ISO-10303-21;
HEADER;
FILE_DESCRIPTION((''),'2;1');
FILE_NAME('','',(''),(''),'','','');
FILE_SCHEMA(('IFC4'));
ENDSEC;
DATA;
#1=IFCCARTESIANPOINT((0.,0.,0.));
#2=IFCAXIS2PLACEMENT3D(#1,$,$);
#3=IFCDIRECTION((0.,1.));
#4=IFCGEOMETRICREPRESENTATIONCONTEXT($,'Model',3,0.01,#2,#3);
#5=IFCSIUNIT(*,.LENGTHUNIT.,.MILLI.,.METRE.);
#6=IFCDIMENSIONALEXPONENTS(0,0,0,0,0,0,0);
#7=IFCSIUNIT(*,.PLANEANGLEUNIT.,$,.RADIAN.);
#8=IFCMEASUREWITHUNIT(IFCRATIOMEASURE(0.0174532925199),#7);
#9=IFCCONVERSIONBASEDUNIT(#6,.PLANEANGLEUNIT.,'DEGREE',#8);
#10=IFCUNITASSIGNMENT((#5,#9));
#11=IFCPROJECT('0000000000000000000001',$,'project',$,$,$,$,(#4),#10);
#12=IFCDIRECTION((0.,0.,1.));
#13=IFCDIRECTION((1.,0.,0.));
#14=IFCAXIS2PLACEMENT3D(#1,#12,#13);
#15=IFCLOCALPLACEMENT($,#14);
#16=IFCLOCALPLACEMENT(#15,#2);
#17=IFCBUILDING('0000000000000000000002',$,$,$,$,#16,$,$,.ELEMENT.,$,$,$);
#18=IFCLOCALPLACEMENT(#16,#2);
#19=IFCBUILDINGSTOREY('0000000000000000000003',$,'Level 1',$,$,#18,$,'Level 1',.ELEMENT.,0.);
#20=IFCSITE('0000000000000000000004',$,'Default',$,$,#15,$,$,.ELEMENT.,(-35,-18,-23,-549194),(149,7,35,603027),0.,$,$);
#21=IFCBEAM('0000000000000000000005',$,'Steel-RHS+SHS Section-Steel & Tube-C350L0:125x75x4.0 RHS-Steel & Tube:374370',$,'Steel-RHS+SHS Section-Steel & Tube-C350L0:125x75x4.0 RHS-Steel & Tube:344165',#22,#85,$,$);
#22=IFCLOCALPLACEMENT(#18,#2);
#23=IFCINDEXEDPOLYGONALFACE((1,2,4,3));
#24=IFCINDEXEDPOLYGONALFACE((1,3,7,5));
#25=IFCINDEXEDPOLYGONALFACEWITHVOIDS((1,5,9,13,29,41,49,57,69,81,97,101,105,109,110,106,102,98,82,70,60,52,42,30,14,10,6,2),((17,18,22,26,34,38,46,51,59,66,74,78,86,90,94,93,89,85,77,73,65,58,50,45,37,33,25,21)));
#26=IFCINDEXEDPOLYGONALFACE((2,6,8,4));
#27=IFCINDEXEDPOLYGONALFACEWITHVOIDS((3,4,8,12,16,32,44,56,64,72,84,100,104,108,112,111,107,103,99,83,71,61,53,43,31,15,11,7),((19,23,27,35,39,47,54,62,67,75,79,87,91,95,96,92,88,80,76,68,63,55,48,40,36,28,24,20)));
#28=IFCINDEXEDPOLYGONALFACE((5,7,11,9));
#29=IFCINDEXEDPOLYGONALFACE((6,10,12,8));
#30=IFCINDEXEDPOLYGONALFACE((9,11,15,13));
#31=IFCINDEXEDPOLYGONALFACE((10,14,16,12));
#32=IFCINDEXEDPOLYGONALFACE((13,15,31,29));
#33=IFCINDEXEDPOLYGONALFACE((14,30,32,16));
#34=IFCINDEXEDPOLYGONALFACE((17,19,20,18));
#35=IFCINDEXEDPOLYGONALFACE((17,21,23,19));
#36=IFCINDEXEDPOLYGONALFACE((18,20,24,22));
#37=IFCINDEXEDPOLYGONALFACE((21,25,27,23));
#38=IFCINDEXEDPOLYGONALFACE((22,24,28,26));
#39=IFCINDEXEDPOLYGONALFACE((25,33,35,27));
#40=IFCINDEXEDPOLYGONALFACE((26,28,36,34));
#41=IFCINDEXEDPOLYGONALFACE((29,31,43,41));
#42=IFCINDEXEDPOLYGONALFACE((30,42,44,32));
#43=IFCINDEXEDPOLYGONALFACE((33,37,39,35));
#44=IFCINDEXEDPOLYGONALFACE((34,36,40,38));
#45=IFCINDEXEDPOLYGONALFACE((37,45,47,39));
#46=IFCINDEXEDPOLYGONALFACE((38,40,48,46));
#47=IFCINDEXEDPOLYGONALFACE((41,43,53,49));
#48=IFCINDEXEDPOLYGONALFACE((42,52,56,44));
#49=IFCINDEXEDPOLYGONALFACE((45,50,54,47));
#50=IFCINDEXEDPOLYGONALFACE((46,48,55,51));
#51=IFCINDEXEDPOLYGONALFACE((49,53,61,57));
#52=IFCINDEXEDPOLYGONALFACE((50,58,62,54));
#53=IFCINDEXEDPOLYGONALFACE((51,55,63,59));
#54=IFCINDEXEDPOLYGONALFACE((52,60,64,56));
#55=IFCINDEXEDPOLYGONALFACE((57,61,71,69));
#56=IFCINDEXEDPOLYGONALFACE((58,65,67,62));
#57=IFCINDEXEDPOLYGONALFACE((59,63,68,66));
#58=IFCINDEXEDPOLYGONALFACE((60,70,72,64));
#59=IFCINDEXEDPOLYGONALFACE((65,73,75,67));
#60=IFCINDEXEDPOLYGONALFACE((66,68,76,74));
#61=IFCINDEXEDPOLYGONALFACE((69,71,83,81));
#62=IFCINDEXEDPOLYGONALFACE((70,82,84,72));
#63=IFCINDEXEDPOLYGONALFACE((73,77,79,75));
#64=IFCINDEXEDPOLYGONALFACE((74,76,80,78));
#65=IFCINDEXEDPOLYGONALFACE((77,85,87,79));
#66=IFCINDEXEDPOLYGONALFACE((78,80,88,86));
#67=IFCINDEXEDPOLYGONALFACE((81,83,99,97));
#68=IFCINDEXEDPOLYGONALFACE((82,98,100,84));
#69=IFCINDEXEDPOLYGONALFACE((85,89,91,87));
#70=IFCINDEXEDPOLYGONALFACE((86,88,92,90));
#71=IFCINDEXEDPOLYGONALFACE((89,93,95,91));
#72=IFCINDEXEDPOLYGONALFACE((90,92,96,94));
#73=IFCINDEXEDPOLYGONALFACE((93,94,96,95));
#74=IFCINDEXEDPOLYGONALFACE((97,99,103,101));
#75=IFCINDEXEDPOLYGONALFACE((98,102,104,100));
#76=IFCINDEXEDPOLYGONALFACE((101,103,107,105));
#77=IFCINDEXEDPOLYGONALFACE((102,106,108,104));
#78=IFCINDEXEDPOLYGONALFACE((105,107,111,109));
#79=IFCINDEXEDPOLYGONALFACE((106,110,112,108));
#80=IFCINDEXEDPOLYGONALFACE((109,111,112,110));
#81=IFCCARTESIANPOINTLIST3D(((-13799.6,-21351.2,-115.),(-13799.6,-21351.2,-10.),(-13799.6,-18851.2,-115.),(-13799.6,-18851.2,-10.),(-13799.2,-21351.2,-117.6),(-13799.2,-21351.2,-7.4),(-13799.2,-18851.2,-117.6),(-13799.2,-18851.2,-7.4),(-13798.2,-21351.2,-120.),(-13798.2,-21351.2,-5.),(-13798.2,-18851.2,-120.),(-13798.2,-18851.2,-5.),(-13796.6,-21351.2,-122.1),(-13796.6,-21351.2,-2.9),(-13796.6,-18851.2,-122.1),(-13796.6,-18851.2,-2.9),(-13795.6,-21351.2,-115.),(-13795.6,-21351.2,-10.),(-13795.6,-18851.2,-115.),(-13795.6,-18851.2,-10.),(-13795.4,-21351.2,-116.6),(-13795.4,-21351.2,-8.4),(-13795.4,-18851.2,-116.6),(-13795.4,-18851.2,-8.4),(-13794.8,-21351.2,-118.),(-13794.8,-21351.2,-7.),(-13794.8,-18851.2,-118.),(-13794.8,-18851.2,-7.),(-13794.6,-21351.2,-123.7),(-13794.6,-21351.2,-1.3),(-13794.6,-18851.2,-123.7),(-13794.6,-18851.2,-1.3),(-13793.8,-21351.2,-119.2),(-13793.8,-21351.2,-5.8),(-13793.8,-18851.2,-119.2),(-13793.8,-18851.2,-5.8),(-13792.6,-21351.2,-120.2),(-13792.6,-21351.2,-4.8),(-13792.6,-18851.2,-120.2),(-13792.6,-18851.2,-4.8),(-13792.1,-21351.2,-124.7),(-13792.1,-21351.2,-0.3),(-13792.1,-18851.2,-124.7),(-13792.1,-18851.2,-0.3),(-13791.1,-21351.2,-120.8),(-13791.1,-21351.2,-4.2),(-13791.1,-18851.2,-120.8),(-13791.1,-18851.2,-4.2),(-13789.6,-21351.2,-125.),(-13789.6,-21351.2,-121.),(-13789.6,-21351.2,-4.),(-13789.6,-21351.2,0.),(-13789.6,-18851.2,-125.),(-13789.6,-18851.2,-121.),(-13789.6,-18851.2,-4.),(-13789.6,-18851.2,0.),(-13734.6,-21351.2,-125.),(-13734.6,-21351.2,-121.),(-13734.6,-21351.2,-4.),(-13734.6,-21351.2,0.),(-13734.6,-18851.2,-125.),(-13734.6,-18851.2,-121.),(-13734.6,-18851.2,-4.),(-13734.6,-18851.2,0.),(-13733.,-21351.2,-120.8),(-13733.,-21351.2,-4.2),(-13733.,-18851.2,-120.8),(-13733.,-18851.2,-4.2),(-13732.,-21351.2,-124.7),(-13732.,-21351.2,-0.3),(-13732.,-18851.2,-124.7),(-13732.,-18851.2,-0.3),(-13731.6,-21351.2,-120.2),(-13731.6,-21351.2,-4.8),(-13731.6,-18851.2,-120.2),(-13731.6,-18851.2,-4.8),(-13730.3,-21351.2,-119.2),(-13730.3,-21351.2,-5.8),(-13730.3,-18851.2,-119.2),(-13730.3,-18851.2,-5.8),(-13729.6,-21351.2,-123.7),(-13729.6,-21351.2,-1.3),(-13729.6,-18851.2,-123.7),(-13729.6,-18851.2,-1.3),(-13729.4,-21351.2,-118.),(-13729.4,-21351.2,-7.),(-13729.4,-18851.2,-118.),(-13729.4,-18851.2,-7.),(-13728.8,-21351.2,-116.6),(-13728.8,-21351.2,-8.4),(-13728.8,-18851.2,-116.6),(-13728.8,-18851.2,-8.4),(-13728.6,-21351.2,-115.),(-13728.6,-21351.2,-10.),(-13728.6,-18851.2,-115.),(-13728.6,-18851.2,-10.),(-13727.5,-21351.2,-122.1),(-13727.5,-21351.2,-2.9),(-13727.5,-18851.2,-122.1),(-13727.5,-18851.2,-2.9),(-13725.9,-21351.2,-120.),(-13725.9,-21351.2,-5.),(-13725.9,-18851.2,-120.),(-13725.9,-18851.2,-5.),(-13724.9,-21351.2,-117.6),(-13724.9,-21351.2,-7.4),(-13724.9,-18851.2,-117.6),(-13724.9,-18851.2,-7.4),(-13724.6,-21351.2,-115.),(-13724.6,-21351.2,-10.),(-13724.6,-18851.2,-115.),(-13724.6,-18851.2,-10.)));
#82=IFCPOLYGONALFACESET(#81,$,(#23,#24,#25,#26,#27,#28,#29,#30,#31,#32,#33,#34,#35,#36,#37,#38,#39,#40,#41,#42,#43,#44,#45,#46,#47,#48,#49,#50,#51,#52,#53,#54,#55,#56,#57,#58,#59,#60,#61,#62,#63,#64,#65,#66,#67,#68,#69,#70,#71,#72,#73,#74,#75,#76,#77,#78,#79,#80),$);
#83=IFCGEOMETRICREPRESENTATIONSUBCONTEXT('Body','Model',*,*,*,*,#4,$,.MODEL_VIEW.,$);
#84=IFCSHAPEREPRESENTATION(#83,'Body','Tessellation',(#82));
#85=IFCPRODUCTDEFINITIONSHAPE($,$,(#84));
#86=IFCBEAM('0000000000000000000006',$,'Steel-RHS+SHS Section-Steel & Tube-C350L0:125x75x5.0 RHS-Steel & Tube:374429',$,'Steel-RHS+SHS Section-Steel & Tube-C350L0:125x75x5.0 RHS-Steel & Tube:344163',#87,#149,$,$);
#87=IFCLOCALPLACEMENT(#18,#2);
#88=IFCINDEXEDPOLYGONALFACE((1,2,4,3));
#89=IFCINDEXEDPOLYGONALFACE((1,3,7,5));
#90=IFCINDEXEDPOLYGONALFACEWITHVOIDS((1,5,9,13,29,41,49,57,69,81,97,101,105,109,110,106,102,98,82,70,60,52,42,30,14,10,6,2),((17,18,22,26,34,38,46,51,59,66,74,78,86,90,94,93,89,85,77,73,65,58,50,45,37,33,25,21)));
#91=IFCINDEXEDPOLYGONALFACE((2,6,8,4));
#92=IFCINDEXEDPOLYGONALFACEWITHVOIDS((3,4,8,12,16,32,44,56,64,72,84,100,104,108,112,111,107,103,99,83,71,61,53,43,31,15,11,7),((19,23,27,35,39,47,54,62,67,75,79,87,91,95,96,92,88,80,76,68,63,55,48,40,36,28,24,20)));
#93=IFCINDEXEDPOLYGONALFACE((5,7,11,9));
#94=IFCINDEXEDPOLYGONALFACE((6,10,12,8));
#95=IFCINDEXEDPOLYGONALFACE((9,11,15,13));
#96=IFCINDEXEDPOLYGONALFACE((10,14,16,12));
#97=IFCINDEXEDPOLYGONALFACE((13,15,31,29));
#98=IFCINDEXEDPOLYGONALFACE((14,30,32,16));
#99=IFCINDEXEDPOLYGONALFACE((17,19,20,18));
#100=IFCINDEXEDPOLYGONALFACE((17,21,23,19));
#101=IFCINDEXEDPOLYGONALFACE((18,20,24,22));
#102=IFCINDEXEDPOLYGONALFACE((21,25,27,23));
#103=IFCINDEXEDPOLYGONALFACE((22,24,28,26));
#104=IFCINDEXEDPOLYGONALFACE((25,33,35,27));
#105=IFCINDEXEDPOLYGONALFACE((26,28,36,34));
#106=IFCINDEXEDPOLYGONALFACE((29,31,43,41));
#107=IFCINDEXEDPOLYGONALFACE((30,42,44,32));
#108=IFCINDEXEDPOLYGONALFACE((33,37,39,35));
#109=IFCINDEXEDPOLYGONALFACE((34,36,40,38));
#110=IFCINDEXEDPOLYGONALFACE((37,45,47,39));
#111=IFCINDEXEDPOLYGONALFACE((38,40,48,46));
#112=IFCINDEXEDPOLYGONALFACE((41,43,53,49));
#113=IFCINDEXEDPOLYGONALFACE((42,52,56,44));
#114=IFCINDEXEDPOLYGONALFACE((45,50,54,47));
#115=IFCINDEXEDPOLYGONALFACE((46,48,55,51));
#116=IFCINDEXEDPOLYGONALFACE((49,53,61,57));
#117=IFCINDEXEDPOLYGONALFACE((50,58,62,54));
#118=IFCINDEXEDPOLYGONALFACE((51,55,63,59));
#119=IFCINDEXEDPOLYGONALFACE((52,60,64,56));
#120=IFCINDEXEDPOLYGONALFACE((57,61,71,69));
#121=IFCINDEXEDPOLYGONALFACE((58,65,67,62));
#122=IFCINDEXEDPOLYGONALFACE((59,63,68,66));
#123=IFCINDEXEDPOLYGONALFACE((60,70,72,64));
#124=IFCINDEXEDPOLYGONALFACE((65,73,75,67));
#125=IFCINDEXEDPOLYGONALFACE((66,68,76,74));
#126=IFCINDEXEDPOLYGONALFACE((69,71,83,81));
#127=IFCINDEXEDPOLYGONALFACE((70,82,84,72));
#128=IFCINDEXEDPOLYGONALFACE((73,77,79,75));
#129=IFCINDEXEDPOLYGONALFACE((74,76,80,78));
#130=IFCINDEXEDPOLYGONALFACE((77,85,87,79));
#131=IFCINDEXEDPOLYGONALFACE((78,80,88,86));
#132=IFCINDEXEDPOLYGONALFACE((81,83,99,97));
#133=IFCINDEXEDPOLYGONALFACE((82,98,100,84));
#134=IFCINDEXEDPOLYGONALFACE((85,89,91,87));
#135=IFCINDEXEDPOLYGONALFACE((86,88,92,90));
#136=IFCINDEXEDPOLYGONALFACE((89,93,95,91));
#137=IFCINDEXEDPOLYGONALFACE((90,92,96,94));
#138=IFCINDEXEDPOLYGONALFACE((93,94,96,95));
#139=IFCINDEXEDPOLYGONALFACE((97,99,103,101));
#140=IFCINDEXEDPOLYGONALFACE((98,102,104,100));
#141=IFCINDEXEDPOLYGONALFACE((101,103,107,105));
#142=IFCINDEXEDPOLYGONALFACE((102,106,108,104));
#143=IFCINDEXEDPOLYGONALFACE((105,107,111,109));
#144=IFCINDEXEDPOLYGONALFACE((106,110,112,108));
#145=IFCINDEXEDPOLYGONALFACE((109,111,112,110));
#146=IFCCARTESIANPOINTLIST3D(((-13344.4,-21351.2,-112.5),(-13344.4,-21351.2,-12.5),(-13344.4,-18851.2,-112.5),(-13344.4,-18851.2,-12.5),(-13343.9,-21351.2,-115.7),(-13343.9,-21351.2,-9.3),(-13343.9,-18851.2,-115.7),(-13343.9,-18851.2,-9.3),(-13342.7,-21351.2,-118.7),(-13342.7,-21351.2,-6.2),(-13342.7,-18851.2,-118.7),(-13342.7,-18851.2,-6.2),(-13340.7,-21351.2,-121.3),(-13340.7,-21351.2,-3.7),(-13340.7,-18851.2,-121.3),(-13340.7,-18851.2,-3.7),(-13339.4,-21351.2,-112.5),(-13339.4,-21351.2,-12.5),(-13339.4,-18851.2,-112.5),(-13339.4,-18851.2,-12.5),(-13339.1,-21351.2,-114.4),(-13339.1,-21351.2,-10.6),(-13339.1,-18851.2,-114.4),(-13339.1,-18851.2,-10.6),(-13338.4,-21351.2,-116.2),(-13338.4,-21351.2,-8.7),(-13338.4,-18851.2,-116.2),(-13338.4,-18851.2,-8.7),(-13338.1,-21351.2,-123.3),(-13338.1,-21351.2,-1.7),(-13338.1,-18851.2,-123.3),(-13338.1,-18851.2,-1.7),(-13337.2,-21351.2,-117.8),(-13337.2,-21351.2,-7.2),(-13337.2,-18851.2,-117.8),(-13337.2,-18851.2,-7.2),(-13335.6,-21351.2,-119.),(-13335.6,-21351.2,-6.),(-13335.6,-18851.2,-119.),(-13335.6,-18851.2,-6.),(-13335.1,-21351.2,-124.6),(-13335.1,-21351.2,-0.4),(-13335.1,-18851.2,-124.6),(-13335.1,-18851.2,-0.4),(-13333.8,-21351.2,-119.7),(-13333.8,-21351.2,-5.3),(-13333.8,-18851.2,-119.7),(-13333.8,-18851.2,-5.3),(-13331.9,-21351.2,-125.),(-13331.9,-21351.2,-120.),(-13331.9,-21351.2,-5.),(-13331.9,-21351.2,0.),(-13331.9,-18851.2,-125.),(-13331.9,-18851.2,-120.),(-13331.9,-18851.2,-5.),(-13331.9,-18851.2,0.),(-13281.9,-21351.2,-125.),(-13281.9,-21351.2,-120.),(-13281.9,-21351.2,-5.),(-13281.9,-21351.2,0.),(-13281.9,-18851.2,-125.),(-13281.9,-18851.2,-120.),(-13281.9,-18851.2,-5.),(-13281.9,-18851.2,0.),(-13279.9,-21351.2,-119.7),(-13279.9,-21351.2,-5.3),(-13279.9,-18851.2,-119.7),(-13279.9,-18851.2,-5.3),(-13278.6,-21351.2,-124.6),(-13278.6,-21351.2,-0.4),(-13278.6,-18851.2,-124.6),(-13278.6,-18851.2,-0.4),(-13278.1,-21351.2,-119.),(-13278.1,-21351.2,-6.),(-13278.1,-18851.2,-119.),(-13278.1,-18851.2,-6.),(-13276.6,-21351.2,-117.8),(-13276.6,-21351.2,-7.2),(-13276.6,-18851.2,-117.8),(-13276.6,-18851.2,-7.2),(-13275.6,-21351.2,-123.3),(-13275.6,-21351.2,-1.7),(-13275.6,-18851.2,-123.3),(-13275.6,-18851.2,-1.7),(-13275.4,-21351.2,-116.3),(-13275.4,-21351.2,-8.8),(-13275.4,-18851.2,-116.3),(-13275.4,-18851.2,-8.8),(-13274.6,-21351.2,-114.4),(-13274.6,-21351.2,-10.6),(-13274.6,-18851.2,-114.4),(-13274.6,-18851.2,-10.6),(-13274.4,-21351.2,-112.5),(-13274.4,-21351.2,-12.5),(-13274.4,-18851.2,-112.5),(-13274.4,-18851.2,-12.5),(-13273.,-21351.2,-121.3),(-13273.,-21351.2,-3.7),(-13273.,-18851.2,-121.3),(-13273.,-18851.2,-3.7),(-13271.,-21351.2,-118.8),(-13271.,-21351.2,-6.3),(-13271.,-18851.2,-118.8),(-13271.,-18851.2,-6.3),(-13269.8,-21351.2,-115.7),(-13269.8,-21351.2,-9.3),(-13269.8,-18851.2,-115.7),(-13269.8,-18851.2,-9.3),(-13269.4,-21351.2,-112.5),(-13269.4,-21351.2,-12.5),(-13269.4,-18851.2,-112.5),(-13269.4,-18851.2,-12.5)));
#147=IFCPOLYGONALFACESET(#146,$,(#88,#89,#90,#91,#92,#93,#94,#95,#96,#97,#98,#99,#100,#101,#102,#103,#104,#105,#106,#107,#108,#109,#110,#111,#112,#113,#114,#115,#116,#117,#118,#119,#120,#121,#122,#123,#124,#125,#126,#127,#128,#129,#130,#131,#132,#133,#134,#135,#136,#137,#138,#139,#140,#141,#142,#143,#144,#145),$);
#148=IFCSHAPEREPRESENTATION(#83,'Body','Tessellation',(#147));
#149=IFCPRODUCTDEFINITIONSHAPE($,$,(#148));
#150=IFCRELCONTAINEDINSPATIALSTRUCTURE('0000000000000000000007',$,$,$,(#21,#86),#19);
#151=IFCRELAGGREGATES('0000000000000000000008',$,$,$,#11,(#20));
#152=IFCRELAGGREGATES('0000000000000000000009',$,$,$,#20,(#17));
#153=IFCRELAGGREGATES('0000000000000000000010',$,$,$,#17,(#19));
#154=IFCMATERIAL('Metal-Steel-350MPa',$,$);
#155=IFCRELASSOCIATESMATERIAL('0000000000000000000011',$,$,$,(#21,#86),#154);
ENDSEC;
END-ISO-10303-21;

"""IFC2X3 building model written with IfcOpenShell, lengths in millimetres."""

from ifc_helpers import new_model, entity, si_unit, converted_unit, direction, frame, frame_2d, origin, origin_with_axes, place, context, subcontext, project, spatial, polyline, circle_curve, parameter, trimmed, segment, composite_curve, outline, extrude, material, element, save


model = new_model("IFC2X3")

# Units and contexts
model_context = context("Model", 3, precision=0.01, world=origin(), true_north=direction((0.0, 1.0)))
body_context = subcontext(model_context, "Body", "Model", "MODEL_VIEW")
ifc_project = project(units=[si_unit("LENGTHUNIT", "METRE", prefix="MILLI"), converted_unit("PLANEANGLEUNIT", "DEGREE", entity("IfcRatioMeasure", 0.0174532925199), si_unit("PLANEANGLEUNIT", "RADIAN"), dimensions=[0, 0, 0, 0, 0, 0, 0])], contexts=[model_context])

# Site, building, storey
site_placement = place(None, origin_with_axes())
site = spatial("IfcSite", under=ifc_project, at=site_placement, Name="Default", CompositionType="ELEMENT", RefLatitude=(-35, -18, -23, -549194), RefLongitude=(149, 7, 35, 603027), RefElevation=0.0)
building_placement = place(site_placement, origin())
building = spatial("IfcBuilding", under=site, at=building_placement, CompositionType="ELEMENT")
storey_placement = place(building_placement, origin())
storey = spatial("IfcBuildingStorey", under=building, at=storey_placement, Name="Level 1", LongName="Level 1", CompositionType="ELEMENT", Elevation=0.0)

# Beams
ifc_material = material(Name="Metal-Steel-350MPa")
beam_1_placement = place(storey_placement, frame((-13762.1, -18851.2, 0.0), z_axis=(0.0, 0.0, 1.0), x_axis=(0.0, -1.0, 0.0)))
element("IfcBeam", 1, at=beam_1_placement, inside=storey, material=ifc_material, Name="Steel-RHS+SHS Section-Steel & Tube-C350L0:125x75x4.0 RHS-Steel & Tube:374370", ObjectType="Steel-RHS+SHS Section-Steel & Tube-C350L0:125x75x4.0 RHS-Steel & Tube:344165", context=body_context, shape_type="SweptSolid", body=[
    extrude(outline(composite_curve([segment(trimmed(circle_curve(frame_2d((-27.5, -52.5), x_axis=(1.0, 0.0)), 10.0), [parameter(180.0)], [parameter(270.0)], True, "PARAMETER"), True, "CONTINUOUS"), segment(polyline([(-27.5, -62.5), (27.5, -62.5)]), True, "CONTINUOUS"), segment(trimmed(circle_curve(frame_2d((27.5, -52.5), x_axis=(1.0, 0.0)), 10.0), [parameter(270.0)], [parameter(0.0)], True, "PARAMETER"), True, "CONTINUOUS"), segment(polyline([(37.5, -52.5), (37.5, 52.5)]), True, "CONTINUOUS"), segment(trimmed(circle_curve(frame_2d((27.5, 52.5), x_axis=(1.0, 0.0)), 10.0), [parameter(0.0)], [parameter(90.0)], True, "PARAMETER"), True, "CONTINUOUS"), segment(polyline([(27.5, 62.5), (-27.5, 62.5)]), True, "CONTINUOUS"), segment(trimmed(circle_curve(frame_2d((-27.5, 52.5), x_axis=(1.0, 0.0)), 10.0), [parameter(90.0)], [parameter(180.0)], True, "PARAMETER"), True, "CONTINUOUS"), segment(polyline([(-37.5, 52.5), (-37.5, -52.5)]), True, "CONTINUOUS")], self_intersect=False), holes=[composite_curve([segment(polyline([(27.5, -58.5), (-27.5, -58.5)]), True, "CONTINUOUS"), segment(trimmed(circle_curve(frame_2d((-27.5, -52.5), x_axis=(1.0, 0.0)), 6.0), [parameter(180.0)], [parameter(270.0)], True, "PARAMETER"), False, "CONTINUOUS"), segment(polyline([(-33.5, -52.5), (-33.5, 52.5)]), True, "CONTINUOUS"), segment(trimmed(circle_curve(frame_2d((-27.5, 52.5), x_axis=(1.0, 0.0)), 6.0), [parameter(90.0)], [parameter(180.0)], True, "PARAMETER"), False, "CONTINUOUS"), segment(polyline([(-27.5, 58.5), (27.5, 58.5)]), True, "CONTINUOUS"), segment(trimmed(circle_curve(frame_2d((27.5, 52.5), x_axis=(1.0, 0.0)), 6.0), [parameter(360.0)], [parameter(90.0)], True, "PARAMETER"), False, "CONTINUOUS"), segment(polyline([(33.5, 52.5), (33.5, -52.5)]), True, "CONTINUOUS"), segment(trimmed(circle_curve(frame_2d((27.5, -52.5), x_axis=(1.0, 0.0)), 6.0), [parameter(270.0)], [parameter(0.0)], True, "PARAMETER"), False, "CONTINUOUS")], self_intersect=False)]), frame((0.0, 0.0, -62.5), z_axis=(1.0, 0.0, 0.0), x_axis=(0.0, -1.0, 0.0)), (0.0, 0.0, 1.0), 2500.0),
])
beam_2_placement = place(storey_placement, frame((-13306.9, -18851.2, 0.0), z_axis=(0.0, 0.0, 1.0), x_axis=(0.0, -1.0, 0.0)))
element("IfcBeam", 2, at=beam_2_placement, inside=storey, material=ifc_material, Name="Steel-RHS+SHS Section-Steel & Tube-C350L0:125x75x5.0 RHS-Steel & Tube:374429", ObjectType="Steel-RHS+SHS Section-Steel & Tube-C350L0:125x75x5.0 RHS-Steel & Tube:344163", context=body_context, shape_type="SweptSolid", body=[
    extrude(outline(composite_curve([segment(trimmed(circle_curve(frame_2d((-25.0, -50.0), x_axis=(1.0, 0.0)), 12.5), [parameter(180.0)], [parameter(270.0)], True, "PARAMETER"), True, "CONTINUOUS"), segment(polyline([(-25.0, -62.5), (25.0, -62.5)]), True, "CONTINUOUS"), segment(trimmed(circle_curve(frame_2d((25.0, -50.0), x_axis=(1.0, 0.0)), 12.5), [parameter(270.0)], [parameter(0.0)], True, "PARAMETER"), True, "CONTINUOUS"), segment(polyline([(37.5, -50.0), (37.5, 50.0)]), True, "CONTINUOUS"), segment(trimmed(circle_curve(frame_2d((25.0, 50.0), x_axis=(1.0, 0.0)), 12.5), [parameter(0.0)], [parameter(90.0)], True, "PARAMETER"), True, "CONTINUOUS"), segment(polyline([(25.0, 62.5), (-25.0, 62.5)]), True, "CONTINUOUS"), segment(trimmed(circle_curve(frame_2d((-25.0, 50.0), x_axis=(1.0, 0.0)), 12.5), [parameter(90.0)], [parameter(180.0)], True, "PARAMETER"), True, "CONTINUOUS"), segment(polyline([(-37.5, 50.0), (-37.5, -50.0)]), True, "CONTINUOUS")], self_intersect=False), holes=[composite_curve([segment(polyline([(25.0, -57.5), (-25.0, -57.5)]), True, "CONTINUOUS"), segment(trimmed(circle_curve(frame_2d((-25.0, -50.0), x_axis=(1.0, 0.0)), 7.5), [parameter(180.0)], [parameter(270.0)], True, "PARAMETER"), False, "CONTINUOUS"), segment(polyline([(-32.5, -50.0), (-32.5, 50.0)]), True, "CONTINUOUS"), segment(trimmed(circle_curve(frame_2d((-25.0, 50.0), x_axis=(1.0, 0.0)), 7.5), [parameter(90.0)], [parameter(180.0)], True, "PARAMETER"), False, "CONTINUOUS"), segment(polyline([(-25.0, 57.5), (25.0, 57.5)]), True, "CONTINUOUS"), segment(trimmed(circle_curve(frame_2d((25.0, 50.0), x_axis=(1.0, 0.0)), 7.5), [parameter(360.0)], [parameter(90.0)], True, "PARAMETER"), False, "CONTINUOUS"), segment(polyline([(32.5, 50.0), (32.5, -50.0)]), True, "CONTINUOUS"), segment(trimmed(circle_curve(frame_2d((25.0, -50.0), x_axis=(1.0, 0.0)), 7.5), [parameter(270.0)], [parameter(0.0)], True, "PARAMETER"), False, "CONTINUOUS")], self_intersect=False)]), frame((0.0, 0.0, -62.5), z_axis=(1.0, 0.0, 0.0), x_axis=(0.0, -1.0, 0.0)), (0.0, 0.0, 1.0), 2500.0),
])

save(model, "model.ifc")
